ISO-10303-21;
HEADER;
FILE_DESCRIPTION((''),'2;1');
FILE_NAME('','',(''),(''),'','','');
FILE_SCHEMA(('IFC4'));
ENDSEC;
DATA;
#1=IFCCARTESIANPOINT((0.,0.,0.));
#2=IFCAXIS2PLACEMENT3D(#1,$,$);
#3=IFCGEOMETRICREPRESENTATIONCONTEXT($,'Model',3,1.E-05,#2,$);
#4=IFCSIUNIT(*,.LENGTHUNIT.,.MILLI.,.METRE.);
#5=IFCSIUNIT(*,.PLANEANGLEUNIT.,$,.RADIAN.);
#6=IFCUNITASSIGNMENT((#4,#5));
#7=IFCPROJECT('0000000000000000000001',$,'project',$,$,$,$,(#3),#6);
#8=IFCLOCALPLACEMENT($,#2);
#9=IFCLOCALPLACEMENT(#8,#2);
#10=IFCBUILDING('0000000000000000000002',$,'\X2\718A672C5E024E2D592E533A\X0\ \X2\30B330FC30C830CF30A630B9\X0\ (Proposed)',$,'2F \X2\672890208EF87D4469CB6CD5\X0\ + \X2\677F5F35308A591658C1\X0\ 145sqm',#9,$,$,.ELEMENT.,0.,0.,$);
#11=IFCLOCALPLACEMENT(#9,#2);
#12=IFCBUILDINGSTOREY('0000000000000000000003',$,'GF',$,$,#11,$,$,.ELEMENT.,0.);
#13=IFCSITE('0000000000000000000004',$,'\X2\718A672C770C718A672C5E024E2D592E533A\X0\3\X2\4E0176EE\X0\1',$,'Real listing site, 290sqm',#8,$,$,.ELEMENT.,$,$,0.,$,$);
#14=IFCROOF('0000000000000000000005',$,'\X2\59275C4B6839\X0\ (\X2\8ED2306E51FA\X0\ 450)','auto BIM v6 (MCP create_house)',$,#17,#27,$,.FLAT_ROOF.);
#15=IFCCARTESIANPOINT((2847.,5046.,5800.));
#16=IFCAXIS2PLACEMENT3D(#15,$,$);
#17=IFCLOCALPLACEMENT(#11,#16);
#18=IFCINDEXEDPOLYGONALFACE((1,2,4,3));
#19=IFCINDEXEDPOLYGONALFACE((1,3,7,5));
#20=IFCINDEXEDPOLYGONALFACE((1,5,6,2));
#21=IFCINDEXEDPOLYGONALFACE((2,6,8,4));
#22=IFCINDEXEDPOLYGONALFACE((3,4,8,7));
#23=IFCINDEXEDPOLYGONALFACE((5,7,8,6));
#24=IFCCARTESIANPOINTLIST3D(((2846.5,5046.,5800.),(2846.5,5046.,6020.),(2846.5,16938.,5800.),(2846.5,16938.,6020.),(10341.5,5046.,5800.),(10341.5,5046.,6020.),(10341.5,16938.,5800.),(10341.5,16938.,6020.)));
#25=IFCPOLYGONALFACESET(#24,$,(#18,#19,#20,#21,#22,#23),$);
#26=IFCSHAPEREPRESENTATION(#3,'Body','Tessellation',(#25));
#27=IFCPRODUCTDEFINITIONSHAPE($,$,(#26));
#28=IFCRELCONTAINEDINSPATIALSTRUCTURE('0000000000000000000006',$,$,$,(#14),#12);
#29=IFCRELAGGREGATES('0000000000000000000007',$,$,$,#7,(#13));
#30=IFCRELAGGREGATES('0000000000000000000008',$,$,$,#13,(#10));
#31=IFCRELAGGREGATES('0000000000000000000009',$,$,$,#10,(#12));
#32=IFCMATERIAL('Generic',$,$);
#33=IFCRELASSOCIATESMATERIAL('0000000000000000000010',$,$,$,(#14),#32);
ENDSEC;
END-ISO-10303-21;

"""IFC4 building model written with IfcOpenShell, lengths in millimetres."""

from ifc_helpers import new_model, si_unit, frame, frame_2d, origin, place, context, project, spatial, rectangle, extrude, material, element, save


model = new_model("IFC4")

# Units and contexts
model_context = context("Model", 3, precision=1e-05, world=origin())
ifc_project = project(units=[si_unit("LENGTHUNIT", "METRE", prefix="MILLI"), si_unit("PLANEANGLEUNIT", "RADIAN")], contexts=[model_context])

# Site, building, storey
site_placement = place(None, origin())
site = spatial("IfcSite", under=ifc_project, at=site_placement, Name="熊本県熊本市中央区3丁目1", ObjectType="Real listing site, 290sqm", CompositionType="ELEMENT", RefElevation=0.0)
building_placement = place(site_placement, origin())
building = spatial("IfcBuilding", under=site, at=building_placement, Name="熊本市中央区 コートハウス (Proposed)", ObjectType="2F 木造軸組構法 + 板張り外壁 145sqm", CompositionType="ELEMENT", ElevationOfRefHeight=0.0, ElevationOfTerrain=0.0)
storey_placement = place(building_placement, origin())
storey = spatial("IfcBuildingStorey", under=building, at=storey_placement, Name="GF", CompositionType="ELEMENT", Elevation=0.0)

# Shared definitions
ifc_material = material(Name="Generic")

# Roof
roof_placement = place(storey_placement, frame((2847.0, 5046.0, 5800.0)))
element("IfcRoof", 1, at=roof_placement, inside=storey, material=ifc_material, Name="大屋根 (軒の出 450)", Description="auto BIM v6 (MCP create_house)", PredefinedType="FLAT_ROOF", context=model_context, shape_type="SweptSolid", body=[
    extrude(rectangle(XDim=7495.0, YDim=11892.0, at=frame_2d((3747.0, 5946.0))), frame((2847.0, 5046.0, 5800.0)), (0.0, 0.0, 1.0), 220.0),
])

save(model, "model.ifc")
